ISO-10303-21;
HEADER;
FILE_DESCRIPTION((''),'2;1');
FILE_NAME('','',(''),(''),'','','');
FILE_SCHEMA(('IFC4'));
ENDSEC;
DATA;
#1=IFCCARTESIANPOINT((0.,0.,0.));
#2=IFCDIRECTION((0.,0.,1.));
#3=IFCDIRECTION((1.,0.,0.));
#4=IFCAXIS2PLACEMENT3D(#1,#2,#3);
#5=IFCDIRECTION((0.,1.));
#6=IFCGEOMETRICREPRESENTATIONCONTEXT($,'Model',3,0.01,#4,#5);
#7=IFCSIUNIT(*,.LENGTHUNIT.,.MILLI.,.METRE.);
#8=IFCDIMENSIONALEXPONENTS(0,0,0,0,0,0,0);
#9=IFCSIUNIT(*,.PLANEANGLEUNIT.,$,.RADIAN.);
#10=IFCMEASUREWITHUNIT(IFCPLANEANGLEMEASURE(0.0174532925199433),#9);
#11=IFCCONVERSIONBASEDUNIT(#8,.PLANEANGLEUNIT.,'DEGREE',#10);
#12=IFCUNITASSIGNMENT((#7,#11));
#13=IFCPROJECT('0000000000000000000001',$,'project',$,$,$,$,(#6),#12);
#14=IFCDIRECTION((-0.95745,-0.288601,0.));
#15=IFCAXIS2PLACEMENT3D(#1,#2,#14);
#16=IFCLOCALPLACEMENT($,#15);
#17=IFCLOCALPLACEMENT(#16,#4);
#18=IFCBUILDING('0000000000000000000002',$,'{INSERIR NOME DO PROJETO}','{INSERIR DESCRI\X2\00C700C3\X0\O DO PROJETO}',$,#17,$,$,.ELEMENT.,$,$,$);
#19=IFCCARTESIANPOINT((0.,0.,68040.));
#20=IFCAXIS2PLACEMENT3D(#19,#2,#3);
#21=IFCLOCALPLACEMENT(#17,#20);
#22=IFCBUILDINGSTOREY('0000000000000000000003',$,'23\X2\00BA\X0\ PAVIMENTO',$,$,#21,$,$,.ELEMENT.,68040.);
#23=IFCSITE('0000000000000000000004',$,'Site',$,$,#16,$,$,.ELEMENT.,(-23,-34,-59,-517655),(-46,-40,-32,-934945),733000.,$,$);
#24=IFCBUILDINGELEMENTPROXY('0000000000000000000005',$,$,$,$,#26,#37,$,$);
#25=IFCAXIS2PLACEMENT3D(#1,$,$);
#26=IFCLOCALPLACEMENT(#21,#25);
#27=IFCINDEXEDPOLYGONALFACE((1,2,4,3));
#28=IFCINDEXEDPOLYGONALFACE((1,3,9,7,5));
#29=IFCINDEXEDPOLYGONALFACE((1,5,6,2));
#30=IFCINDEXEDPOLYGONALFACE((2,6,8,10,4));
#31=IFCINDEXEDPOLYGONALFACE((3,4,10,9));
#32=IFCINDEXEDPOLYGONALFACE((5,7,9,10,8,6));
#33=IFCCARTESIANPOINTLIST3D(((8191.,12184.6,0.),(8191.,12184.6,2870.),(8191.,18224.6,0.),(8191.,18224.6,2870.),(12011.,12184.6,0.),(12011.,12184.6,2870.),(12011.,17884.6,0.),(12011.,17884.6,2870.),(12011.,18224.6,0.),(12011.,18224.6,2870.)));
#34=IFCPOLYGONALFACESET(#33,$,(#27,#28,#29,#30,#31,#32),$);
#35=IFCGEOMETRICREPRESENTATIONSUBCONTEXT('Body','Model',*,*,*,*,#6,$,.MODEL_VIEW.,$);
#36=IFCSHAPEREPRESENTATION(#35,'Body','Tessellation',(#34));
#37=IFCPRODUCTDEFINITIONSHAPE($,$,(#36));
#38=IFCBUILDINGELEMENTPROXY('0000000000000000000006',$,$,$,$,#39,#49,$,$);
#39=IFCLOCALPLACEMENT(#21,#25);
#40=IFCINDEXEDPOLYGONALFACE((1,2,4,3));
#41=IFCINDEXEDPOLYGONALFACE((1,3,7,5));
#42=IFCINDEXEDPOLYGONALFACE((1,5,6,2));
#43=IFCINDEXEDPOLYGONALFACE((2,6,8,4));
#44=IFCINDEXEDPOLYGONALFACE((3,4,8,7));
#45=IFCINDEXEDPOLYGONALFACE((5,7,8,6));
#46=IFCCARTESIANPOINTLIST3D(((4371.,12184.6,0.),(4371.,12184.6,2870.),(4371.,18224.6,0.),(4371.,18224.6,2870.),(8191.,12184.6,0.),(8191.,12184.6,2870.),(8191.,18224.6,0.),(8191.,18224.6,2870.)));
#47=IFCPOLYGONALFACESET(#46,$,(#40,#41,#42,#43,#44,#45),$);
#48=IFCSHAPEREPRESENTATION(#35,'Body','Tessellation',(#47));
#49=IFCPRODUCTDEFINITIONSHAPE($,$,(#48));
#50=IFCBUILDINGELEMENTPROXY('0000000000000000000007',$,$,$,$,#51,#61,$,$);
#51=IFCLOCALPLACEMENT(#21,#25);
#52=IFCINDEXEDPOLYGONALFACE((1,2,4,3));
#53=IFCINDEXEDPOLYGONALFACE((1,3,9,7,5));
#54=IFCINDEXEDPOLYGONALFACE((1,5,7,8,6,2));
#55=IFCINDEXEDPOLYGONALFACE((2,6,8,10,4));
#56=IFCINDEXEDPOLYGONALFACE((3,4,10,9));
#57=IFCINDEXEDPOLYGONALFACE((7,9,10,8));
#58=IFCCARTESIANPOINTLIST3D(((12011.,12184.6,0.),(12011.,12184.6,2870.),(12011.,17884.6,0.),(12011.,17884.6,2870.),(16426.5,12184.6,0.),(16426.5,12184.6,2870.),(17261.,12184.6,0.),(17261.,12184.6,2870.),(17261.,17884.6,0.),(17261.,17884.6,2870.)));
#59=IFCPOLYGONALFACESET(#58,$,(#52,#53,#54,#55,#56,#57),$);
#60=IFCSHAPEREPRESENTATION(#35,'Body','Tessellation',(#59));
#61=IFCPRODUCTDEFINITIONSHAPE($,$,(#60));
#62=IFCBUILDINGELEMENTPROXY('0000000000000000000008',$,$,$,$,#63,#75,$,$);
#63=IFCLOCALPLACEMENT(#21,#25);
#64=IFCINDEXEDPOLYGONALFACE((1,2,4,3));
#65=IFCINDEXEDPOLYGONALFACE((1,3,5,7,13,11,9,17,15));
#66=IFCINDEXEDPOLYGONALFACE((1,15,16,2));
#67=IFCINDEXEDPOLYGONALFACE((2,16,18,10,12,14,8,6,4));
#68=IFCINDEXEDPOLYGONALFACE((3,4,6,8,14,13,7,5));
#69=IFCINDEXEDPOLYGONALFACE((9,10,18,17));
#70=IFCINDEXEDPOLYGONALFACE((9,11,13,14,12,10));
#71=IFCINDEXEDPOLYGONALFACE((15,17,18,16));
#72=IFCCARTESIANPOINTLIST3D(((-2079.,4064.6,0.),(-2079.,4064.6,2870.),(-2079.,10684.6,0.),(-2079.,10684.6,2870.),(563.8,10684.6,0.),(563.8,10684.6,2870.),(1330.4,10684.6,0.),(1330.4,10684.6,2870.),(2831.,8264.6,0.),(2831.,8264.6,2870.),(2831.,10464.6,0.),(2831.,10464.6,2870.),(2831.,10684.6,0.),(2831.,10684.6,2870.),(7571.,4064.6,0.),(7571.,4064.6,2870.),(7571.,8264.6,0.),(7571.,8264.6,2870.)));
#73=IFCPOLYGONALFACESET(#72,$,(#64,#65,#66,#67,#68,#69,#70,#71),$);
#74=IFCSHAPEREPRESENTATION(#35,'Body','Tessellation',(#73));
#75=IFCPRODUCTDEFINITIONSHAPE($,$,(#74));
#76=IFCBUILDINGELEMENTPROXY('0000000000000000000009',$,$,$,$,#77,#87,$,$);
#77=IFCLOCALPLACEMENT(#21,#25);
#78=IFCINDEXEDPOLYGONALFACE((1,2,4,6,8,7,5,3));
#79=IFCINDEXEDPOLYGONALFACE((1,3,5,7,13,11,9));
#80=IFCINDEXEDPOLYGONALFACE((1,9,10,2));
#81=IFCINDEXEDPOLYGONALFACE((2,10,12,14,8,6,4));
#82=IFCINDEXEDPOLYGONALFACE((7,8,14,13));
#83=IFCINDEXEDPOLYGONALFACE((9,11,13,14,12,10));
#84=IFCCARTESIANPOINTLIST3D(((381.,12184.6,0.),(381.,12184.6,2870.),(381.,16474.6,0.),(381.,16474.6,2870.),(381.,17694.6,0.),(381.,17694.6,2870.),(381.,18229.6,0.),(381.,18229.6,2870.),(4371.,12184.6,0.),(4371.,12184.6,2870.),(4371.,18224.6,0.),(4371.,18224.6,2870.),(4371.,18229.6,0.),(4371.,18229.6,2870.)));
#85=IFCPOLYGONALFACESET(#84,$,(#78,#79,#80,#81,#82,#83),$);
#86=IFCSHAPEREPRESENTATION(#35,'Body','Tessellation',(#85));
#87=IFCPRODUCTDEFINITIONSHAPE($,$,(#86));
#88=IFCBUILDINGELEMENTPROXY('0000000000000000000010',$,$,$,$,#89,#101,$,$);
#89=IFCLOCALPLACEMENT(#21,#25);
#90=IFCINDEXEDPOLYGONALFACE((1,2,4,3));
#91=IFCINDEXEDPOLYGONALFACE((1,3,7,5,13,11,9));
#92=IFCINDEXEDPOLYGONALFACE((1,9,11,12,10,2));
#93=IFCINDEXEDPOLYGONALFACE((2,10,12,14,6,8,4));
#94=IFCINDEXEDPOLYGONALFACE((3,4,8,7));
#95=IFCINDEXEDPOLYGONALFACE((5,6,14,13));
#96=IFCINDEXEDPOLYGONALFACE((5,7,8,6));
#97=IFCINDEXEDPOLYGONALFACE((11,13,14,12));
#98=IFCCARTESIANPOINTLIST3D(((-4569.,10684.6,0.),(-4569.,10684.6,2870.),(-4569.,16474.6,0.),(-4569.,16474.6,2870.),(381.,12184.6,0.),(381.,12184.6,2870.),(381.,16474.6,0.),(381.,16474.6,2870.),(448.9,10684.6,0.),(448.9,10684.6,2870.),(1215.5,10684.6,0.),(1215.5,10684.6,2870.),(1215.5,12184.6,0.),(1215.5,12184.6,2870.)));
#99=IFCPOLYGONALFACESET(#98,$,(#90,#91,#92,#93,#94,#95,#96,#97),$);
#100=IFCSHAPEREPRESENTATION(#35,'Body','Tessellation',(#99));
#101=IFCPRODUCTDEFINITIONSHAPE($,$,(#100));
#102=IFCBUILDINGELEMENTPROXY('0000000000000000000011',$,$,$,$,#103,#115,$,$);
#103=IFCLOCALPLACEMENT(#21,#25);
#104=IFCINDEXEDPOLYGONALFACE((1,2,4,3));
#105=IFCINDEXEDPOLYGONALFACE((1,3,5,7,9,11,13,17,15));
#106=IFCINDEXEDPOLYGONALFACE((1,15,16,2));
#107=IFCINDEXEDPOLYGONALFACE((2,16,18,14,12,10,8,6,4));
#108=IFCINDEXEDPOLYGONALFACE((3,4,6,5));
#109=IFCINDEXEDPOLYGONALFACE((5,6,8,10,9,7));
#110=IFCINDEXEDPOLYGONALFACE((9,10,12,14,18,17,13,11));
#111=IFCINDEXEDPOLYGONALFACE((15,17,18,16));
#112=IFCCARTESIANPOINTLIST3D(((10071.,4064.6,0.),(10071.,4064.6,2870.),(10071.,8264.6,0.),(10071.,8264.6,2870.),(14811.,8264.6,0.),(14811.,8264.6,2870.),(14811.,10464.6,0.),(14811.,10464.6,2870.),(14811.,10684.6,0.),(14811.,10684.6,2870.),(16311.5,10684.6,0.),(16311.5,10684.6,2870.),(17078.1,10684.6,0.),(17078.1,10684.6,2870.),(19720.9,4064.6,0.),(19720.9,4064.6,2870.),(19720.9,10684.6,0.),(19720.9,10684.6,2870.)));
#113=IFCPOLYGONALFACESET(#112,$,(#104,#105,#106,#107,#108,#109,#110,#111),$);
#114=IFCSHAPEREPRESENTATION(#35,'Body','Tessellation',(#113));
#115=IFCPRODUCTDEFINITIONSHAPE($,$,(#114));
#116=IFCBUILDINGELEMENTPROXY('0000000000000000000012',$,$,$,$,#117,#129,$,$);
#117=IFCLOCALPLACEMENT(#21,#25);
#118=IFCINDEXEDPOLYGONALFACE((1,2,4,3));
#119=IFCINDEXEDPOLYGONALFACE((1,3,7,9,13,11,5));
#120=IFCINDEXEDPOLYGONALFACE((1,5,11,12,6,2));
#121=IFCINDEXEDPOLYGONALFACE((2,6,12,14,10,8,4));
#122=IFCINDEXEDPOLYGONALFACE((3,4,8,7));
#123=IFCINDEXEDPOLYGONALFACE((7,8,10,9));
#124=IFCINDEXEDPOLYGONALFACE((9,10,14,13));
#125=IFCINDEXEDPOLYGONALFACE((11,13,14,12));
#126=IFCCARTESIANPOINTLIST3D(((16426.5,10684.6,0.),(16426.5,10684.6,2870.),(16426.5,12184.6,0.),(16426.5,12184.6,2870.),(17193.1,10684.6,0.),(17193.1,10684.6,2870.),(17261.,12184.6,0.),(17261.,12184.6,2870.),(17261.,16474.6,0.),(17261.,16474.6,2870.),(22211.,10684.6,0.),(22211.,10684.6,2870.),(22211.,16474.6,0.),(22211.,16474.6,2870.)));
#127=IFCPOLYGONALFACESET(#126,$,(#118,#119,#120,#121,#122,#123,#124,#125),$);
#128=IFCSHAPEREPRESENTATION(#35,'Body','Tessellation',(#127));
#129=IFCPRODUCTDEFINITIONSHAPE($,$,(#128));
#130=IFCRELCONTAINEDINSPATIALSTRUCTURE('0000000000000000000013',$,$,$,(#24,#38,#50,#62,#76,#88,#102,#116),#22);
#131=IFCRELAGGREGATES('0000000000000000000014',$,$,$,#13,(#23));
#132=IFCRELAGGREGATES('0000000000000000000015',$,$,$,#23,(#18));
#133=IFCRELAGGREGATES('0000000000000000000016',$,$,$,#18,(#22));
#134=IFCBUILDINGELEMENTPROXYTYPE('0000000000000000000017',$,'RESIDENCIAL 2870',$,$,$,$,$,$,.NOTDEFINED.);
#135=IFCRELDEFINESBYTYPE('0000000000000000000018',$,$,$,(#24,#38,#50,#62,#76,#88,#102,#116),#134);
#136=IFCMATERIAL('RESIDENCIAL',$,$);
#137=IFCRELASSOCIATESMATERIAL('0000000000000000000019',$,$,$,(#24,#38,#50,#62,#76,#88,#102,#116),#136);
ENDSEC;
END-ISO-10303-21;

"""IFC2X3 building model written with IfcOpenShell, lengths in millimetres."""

from ifc_helpers import new_model, entity, si_unit, converted_unit, direction, frame, origin_with_axes, place, context, subcontext, project, spatial, polyline, outline, extrude, material, type_object, element, save


model = new_model("IFC2X3")

# Units and contexts
model_context = context("Model", 3, precision=0.01, world=origin_with_axes(), true_north=direction((0.0, 1.0)))
body_context = subcontext(model_context, "Body", "Model", "MODEL_VIEW")
ifc_project = project(units=[si_unit("LENGTHUNIT", "METRE", prefix="MILLI"), converted_unit("PLANEANGLEUNIT", "DEGREE", entity("IfcPlaneAngleMeasure", 0.0174532925199433), si_unit("PLANEANGLEUNIT", "RADIAN"), dimensions=[0, 0, 0, 0, 0, 0, 0])], contexts=[model_context])

# Site, building, storey
site_placement = place(None, frame((0.0, 0.0, 0.0), z_axis=(0.0, 0.0, 1.0), x_axis=(-0.95745, -0.288601, 0.0)))
site = spatial("IfcSite", under=ifc_project, at=site_placement, Name="Site", CompositionType="ELEMENT", RefLatitude=(-23, -34, -59, -517655), RefLongitude=(-46, -40, -32, -934945), RefElevation=733000.0)
building_placement = place(site_placement, origin_with_axes())
building = spatial("IfcBuilding", under=site, at=building_placement, Name="{INSERIR NOME DO PROJETO}", Description="{INSERIR DESCRIÇÃO DO PROJETO}", CompositionType="ELEMENT")
storey_placement = place(building_placement, frame((0.0, 0.0, 68040.0), z_axis=(0.0, 0.0, 1.0), x_axis=(1.0, 0.0, 0.0)))
storey = spatial("IfcBuildingStorey", under=building, at=storey_placement, Name="23º PAVIMENTO", CompositionType="ELEMENT", Elevation=68040.0)

# Building element proxies
ifc_material_1 = material(Name="RESIDENCIAL")
building_element_proxy_type_1 = type_object("IfcBuildingElementProxyType", Name="RESIDENCIAL 2870", PredefinedType="NOTDEFINED")
proxy_1_placement = place(storey_placement, frame((8191.0, 18224.6, 0.0), z_axis=(0.0, 0.0, 1.0), x_axis=(1.0, 0.0, 0.0)))
element("IfcBuildingElementProxy", 1, at=proxy_1_placement, inside=storey, type_object=building_element_proxy_type_1, material=ifc_material_1, context=body_context, shape_type="SweptSolid", body=[
    extrude(outline(polyline([(0.0, 0.0), (0.0, -6040.0), (3820.0, -6040.0), (3820.0, -340.0), (3820.0, 0.0), (0.0, 0.0)])), origin_with_axes(), (0.0, 0.0, 1.0), 2870.0),
])
proxy_2_placement = place(storey_placement, frame((4371.0, 18224.6, 0.0), z_axis=(0.0, 0.0, 1.0), x_axis=(1.0, 0.0, 0.0)))
element("IfcBuildingElementProxy", 2, at=proxy_2_placement, inside=storey, type_object=building_element_proxy_type_1, material=ifc_material_1, context=body_context, shape_type="SweptSolid", body=[
    extrude(outline(polyline([(0.0, 0.0), (0.0, -6040.0), (3820.0, -6040.0), (3820.0, 0.0), (0.0, 0.0)])), origin_with_axes(), (0.0, 0.0, 1.0), 2870.0),
])
proxy_3_placement = place(storey_placement, frame((12011.0, 12184.6, 0.0), z_axis=(0.0, 0.0, 1.0), x_axis=(1.0, 0.0, 0.0)))
element("IfcBuildingElementProxy", 3, at=proxy_3_placement, inside=storey, type_object=building_element_proxy_type_1, material=ifc_material_1, context=body_context, shape_type="SweptSolid", body=[
    extrude(outline(polyline([(0.0, 0.0), (4415.5, 0.0), (5250.0, 0.0), (5250.0, 5700.0), (0.0, 5700.0), (0.0, 0.0)])), origin_with_axes(), (0.0, 0.0, 1.0), 2870.0),
])
proxy_4_placement = place(storey_placement, frame((-2079.0, 4064.6, 0.0), z_axis=(0.0, 0.0, 1.0), x_axis=(1.0, 0.0, 0.0)))
element("IfcBuildingElementProxy", 4, at=proxy_4_placement, inside=storey, type_object=building_element_proxy_type_1, material=ifc_material_1, context=body_context, shape_type="SweptSolid", body=[
    extrude(outline(polyline([(0.0, 0.0), (9650.0, 0.0), (9650.0, 4200.0), (4910.0, 4200.0), (4910.0, 6400.0), (4910.0, 6620.0), (3409.4, 6620.0), (2642.8, 6620.0), (0.0, 6620.0), (0.0, 0.0)])), origin_with_axes(), (0.0, 0.0, 1.0), 2870.0),
])
proxy_5_placement = place(storey_placement, frame((381.0, 16474.6, 0.0), z_axis=(0.0, 0.0, 1.0), x_axis=(1.0, 0.0, 0.0)))
element("IfcBuildingElementProxy", 5, at=proxy_5_placement, inside=storey, type_object=building_element_proxy_type_1, material=ifc_material_1, context=body_context, shape_type="SweptSolid", body=[
    extrude(outline(polyline([(0.0, 0.0), (0.0, -4290.0), (3990.0, -4290.0), (3990.0, 1750.0), (3990.0, 1755.0), (0.0, 1755.0), (0.0, 1220.0), (0.0, 0.0)])), origin_with_axes(), (0.0, 0.0, 1.0), 2870.0),
])
proxy_6_placement = place(storey_placement, frame((-4569.0, 16474.6, 0.0), z_axis=(0.0, 0.0, 1.0), x_axis=(1.0, 0.0, 0.0)))
element("IfcBuildingElementProxy", 6, at=proxy_6_placement, inside=storey, type_object=building_element_proxy_type_1, material=ifc_material_1, context=body_context, shape_type="SweptSolid", body=[
    extrude(outline(polyline([(0.0, 0.0), (0.0, -5790.0), (5017.9, -5790.0), (5784.5, -5790.0), (5784.5, -4290.0), (4950.0, -4290.0), (4950.0, 0.0), (0.0, 0.0)])), origin_with_axes(), (0.0, 0.0, 1.0), 2870.0),
])
proxy_7_placement = place(storey_placement, frame((19720.9, 4064.6, 0.0), z_axis=(0.0, 0.0, 1.0), x_axis=(1.0, 0.0, 0.0)))
element("IfcBuildingElementProxy", 7, at=proxy_7_placement, inside=storey, type_object=building_element_proxy_type_1, material=ifc_material_1, context=body_context, shape_type="SweptSolid", body=[
    extrude(outline(polyline([(0.0, 0.0), (0.0, 6620.0), (-2642.8, 6620.0), (-3409.4, 6620.0), (-4910.0, 6620.0), (-4910.0, 6400.0), (-4910.0, 4200.0), (-9650.0, 4200.0), (-9650.0, 0.0), (0.0, 0.0)])), origin_with_axes(), (0.0, 0.0, 1.0), 2870.0),
])
proxy_8_placement = place(storey_placement, frame((17261.0, 12184.6, 0.0), z_axis=(0.0, 0.0, 1.0), x_axis=(1.0, 0.0, 0.0)))
element("IfcBuildingElementProxy", 8, at=proxy_8_placement, inside=storey, type_object=building_element_proxy_type_1, material=ifc_material_1, context=body_context, shape_type="SweptSolid", body=[
    extrude(outline(polyline([(0.0, 0.0), (-834.5, 0.0), (-834.5, -1500.0), (-67.9, -1500.0), (4950.0, -1500.0), (4950.0, 4290.0), (0.0, 4290.0), (0.0, 0.0)])), origin_with_axes(), (0.0, 0.0, 1.0), 2870.0),
])

save(model, "model.ifc")
